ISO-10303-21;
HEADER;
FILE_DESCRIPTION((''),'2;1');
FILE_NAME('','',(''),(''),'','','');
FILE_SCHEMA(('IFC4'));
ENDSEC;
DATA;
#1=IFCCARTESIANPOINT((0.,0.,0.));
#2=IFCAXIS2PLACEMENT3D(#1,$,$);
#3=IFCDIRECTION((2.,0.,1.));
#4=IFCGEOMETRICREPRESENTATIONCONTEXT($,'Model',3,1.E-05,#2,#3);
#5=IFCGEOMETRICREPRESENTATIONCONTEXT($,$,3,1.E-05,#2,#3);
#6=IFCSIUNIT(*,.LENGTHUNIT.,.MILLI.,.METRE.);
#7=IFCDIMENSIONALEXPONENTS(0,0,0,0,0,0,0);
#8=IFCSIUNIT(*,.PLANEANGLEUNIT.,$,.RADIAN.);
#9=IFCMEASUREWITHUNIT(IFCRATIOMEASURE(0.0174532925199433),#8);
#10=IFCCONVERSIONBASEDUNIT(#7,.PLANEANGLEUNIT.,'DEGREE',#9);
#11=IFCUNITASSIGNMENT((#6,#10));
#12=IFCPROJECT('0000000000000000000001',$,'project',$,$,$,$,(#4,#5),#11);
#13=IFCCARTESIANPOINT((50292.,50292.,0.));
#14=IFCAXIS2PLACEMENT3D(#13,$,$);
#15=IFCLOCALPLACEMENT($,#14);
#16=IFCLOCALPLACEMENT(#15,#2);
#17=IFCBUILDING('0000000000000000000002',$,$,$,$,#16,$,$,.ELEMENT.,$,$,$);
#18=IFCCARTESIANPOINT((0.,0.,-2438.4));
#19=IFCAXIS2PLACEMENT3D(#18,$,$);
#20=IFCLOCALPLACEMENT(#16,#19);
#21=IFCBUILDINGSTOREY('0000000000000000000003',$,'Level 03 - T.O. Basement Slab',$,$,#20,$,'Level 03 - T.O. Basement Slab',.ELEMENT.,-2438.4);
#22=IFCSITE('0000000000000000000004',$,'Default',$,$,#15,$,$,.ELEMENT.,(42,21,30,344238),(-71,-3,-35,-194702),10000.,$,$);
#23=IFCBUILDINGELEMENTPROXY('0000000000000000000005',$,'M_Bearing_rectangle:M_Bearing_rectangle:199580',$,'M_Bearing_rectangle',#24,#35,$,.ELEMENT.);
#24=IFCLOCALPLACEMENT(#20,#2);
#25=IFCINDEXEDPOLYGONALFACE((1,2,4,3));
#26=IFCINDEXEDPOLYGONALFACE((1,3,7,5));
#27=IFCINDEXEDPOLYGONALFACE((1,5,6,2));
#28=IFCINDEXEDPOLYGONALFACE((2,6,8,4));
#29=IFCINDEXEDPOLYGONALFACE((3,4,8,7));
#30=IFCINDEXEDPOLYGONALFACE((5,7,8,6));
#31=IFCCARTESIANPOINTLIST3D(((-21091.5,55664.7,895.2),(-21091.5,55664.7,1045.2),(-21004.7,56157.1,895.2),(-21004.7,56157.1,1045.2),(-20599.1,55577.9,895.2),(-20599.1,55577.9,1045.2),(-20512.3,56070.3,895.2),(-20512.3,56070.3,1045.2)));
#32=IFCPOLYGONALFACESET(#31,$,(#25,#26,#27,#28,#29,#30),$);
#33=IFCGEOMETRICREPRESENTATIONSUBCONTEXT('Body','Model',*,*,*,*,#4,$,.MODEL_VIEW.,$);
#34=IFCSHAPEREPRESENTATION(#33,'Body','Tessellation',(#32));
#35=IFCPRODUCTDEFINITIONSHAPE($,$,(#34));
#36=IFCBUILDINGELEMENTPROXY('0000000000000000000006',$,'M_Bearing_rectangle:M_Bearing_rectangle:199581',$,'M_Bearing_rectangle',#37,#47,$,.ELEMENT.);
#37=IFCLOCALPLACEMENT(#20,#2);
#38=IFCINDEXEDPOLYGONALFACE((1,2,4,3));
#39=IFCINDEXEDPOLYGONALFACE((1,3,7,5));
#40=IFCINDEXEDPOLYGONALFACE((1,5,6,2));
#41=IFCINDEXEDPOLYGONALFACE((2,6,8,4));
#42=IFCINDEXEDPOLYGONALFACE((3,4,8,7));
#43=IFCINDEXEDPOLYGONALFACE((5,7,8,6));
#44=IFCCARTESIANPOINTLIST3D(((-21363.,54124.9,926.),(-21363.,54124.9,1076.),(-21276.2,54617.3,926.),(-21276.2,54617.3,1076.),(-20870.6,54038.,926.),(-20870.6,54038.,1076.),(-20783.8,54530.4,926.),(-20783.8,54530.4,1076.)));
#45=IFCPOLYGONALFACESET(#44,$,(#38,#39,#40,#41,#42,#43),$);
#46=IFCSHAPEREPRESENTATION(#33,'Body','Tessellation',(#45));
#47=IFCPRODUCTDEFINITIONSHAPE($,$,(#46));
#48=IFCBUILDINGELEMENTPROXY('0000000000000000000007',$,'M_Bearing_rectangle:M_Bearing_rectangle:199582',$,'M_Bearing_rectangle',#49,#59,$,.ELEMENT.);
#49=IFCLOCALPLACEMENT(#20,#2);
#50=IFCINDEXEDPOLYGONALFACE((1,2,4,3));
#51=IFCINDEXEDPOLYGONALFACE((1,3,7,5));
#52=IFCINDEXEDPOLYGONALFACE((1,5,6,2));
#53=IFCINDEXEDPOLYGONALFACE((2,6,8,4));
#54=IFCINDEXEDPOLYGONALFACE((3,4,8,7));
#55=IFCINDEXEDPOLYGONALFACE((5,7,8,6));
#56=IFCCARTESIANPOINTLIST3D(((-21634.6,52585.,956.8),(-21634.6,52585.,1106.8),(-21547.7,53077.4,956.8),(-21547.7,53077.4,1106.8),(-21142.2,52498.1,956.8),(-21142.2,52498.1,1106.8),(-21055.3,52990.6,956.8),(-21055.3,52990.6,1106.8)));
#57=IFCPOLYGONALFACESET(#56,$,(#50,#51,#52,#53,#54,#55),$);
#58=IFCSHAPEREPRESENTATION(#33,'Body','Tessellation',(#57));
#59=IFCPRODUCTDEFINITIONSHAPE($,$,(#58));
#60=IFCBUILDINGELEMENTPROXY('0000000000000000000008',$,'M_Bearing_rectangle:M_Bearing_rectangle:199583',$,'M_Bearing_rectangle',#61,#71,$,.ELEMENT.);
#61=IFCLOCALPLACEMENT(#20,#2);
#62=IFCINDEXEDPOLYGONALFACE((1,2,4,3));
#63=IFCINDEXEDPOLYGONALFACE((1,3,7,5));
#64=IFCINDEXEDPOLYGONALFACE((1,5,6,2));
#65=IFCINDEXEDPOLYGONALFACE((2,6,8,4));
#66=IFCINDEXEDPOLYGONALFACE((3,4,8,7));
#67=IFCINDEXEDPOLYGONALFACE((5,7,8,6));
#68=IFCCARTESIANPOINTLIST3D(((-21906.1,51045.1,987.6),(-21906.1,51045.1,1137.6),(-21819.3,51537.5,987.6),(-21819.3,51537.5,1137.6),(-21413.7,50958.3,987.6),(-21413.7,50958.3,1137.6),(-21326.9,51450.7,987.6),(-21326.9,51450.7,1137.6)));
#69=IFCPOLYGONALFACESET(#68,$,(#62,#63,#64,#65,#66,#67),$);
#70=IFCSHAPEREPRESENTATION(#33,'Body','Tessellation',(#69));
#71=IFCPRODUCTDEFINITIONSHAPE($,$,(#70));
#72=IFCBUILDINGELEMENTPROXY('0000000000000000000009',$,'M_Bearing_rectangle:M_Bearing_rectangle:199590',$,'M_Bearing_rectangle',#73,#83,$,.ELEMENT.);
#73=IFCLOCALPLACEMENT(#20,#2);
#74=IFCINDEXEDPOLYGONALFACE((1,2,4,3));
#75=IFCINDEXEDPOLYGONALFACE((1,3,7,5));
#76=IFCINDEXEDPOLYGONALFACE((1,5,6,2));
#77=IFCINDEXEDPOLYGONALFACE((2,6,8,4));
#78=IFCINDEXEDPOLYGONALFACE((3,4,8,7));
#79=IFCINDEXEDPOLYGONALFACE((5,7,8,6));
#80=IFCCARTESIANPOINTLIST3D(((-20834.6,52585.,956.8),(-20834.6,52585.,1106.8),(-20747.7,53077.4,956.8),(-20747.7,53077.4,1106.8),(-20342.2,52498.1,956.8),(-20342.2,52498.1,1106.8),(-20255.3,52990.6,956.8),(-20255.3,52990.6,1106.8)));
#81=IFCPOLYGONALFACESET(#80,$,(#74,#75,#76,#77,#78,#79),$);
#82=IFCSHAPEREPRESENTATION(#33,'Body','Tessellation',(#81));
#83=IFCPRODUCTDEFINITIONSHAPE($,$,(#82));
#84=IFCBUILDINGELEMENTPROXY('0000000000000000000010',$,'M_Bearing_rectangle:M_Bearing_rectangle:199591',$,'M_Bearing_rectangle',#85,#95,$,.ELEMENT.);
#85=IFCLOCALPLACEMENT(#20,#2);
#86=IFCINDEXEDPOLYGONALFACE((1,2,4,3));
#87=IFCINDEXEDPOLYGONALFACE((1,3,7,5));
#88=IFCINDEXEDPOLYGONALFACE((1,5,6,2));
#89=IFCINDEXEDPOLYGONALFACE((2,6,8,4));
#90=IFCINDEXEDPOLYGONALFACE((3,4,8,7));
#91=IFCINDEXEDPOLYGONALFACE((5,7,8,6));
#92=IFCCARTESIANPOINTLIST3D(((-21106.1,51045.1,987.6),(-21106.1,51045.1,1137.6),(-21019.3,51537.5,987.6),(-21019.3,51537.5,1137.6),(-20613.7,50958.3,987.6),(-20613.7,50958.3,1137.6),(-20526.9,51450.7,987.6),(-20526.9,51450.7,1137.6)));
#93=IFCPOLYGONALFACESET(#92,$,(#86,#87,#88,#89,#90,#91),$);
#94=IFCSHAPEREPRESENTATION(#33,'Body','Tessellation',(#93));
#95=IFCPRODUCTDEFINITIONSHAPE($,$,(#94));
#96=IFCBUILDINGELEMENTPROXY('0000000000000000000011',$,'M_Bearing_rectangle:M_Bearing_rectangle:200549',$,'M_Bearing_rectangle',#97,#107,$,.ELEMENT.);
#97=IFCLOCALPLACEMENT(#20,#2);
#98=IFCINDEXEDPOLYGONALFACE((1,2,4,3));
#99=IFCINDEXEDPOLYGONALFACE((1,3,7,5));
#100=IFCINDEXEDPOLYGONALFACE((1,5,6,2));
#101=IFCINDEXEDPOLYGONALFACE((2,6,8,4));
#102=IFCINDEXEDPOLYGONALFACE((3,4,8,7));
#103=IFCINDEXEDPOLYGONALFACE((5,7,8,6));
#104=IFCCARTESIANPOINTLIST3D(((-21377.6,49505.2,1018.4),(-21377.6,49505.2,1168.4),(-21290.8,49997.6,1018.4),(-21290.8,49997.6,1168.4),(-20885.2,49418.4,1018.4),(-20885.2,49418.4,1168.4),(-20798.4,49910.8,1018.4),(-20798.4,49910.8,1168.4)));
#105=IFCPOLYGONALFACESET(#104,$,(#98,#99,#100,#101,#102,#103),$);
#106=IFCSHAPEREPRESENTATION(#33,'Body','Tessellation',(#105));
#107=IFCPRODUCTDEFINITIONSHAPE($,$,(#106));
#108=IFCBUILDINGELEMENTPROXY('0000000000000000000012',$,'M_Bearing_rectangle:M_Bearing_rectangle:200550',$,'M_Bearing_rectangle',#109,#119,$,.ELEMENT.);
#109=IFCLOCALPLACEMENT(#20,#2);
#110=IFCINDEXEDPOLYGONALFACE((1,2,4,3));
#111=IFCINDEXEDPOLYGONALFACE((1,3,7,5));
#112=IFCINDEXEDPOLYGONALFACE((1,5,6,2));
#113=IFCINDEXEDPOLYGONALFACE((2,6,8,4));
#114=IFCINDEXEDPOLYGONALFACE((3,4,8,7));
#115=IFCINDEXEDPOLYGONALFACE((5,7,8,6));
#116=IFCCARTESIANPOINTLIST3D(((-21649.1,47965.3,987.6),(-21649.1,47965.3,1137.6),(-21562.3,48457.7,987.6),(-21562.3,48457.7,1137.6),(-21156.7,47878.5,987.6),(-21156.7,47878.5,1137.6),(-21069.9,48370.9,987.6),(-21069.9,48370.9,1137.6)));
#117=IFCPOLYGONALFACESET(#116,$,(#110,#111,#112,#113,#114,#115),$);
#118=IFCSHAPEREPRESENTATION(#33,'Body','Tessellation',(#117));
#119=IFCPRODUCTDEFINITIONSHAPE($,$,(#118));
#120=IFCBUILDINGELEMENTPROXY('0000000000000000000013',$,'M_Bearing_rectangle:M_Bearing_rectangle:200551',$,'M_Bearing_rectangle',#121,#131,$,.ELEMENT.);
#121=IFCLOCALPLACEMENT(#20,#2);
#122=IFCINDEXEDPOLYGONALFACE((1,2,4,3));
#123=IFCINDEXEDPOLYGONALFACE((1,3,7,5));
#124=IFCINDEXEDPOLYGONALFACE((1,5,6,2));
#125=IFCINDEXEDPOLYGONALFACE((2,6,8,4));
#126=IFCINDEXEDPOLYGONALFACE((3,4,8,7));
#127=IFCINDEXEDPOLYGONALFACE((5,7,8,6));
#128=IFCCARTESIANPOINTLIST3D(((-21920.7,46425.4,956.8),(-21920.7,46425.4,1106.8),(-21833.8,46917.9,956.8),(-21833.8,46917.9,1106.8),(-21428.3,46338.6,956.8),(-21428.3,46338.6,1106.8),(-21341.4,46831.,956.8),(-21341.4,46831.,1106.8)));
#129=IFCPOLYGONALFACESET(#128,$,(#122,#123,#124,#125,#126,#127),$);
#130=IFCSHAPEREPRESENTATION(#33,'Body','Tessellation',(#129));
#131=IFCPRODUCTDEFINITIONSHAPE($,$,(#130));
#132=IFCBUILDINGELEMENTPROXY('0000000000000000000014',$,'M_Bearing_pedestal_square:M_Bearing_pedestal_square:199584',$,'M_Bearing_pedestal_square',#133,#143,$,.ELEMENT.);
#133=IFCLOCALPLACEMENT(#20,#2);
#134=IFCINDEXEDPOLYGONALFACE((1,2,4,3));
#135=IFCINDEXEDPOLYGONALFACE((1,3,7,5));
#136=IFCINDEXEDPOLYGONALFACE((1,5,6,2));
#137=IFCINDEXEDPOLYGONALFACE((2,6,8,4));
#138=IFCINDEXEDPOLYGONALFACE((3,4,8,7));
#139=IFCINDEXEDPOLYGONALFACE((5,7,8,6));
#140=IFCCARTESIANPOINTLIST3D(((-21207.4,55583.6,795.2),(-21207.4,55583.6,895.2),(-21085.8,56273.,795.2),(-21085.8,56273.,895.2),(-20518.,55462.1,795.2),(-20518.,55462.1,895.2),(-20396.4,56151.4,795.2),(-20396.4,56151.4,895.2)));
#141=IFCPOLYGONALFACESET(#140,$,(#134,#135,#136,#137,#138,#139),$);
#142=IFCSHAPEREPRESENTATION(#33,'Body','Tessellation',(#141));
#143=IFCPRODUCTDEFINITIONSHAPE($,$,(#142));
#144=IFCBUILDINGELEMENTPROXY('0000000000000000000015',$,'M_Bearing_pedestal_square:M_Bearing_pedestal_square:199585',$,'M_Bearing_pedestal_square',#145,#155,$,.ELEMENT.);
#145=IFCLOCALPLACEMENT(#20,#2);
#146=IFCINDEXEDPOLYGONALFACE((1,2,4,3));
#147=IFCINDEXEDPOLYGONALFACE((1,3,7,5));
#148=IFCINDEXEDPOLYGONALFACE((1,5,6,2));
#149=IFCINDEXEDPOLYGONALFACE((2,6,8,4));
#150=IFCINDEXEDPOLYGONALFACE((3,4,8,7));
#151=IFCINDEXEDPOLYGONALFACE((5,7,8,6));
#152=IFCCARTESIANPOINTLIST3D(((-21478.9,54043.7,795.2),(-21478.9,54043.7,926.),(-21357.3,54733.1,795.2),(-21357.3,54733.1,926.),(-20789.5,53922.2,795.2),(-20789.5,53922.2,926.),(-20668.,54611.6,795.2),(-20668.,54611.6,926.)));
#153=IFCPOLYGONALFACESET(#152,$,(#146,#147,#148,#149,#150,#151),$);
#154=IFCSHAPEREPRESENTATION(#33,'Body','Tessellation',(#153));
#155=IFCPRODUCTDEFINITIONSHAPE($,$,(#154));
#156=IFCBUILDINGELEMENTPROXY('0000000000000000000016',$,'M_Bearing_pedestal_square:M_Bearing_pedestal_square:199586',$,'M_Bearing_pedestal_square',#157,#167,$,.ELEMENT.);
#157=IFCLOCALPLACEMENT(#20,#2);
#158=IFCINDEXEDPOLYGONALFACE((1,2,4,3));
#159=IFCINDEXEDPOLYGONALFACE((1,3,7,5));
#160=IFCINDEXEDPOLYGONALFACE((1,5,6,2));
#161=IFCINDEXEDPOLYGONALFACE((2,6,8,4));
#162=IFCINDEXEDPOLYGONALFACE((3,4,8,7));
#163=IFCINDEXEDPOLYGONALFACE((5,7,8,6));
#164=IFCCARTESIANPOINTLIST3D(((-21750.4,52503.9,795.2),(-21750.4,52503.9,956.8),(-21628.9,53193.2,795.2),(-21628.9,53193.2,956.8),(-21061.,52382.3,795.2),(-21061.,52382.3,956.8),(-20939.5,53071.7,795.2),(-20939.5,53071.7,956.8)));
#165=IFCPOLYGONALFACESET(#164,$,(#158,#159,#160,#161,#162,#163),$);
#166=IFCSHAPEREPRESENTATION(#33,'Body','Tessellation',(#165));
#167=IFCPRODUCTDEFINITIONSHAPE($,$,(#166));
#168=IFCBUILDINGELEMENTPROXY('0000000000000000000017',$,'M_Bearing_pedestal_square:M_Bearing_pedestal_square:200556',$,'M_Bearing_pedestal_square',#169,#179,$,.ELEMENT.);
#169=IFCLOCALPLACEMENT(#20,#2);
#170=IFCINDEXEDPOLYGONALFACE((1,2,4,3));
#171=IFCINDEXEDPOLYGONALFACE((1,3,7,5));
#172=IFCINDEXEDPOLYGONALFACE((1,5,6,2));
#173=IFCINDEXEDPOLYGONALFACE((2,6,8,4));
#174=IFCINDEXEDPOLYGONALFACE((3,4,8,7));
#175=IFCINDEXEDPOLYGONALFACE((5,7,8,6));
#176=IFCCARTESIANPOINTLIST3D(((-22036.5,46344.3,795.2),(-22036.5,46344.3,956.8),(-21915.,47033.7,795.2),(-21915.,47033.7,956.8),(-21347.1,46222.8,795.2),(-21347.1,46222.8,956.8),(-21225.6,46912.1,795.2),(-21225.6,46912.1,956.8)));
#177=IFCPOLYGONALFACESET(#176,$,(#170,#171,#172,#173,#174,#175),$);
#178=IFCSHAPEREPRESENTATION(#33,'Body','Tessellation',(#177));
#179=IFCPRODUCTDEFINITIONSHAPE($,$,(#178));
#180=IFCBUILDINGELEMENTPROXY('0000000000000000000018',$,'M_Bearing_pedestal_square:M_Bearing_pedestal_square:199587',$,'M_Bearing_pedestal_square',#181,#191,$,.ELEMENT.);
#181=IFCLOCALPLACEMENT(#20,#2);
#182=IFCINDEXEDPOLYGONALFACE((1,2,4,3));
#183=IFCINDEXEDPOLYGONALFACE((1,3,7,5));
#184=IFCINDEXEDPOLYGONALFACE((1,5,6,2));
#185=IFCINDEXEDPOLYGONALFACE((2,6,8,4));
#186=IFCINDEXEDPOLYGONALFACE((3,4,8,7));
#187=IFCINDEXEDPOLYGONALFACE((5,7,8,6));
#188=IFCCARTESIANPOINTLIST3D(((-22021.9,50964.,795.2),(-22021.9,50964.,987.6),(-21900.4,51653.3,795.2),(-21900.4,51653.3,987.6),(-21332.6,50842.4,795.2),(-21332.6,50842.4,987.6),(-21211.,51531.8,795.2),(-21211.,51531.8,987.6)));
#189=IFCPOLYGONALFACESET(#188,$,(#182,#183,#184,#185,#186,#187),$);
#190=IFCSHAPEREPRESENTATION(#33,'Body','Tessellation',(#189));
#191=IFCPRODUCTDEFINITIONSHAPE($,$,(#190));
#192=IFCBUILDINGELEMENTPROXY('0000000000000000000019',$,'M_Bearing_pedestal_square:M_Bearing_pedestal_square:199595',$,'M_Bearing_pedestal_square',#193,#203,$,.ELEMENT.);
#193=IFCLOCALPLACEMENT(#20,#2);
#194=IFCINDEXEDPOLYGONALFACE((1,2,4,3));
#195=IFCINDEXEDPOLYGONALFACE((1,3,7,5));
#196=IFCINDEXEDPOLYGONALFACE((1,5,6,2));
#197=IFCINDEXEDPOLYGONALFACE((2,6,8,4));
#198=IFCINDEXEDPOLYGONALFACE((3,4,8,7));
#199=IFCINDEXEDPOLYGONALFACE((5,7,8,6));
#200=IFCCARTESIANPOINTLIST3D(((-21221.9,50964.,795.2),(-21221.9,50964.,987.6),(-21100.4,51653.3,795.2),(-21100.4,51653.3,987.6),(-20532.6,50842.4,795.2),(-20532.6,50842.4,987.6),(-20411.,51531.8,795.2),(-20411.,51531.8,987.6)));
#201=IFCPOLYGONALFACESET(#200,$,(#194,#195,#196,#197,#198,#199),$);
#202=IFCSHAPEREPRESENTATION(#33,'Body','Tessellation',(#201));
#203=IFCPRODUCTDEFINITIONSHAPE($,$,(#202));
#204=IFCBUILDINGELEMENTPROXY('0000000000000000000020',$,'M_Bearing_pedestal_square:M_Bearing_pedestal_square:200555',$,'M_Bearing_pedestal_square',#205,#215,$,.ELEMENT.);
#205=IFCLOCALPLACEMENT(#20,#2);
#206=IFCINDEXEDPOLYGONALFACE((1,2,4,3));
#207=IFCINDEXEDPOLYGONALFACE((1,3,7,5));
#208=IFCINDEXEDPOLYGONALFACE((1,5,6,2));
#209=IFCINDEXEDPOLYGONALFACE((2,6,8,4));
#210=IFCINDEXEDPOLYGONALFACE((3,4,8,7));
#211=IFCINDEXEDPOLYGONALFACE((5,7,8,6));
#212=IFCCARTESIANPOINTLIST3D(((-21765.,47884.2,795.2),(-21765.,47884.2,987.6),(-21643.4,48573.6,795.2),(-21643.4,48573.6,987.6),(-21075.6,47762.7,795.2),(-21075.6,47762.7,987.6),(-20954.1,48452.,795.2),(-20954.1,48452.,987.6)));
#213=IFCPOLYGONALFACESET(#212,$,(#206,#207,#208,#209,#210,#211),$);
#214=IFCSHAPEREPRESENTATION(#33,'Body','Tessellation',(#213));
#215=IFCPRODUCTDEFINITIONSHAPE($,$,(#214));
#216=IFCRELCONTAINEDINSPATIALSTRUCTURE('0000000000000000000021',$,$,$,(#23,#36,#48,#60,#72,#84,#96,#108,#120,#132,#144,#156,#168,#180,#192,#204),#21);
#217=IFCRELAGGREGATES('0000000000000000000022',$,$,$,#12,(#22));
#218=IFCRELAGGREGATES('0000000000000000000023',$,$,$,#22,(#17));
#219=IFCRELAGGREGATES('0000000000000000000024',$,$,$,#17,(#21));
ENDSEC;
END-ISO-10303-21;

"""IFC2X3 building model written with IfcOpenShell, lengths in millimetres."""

from ifc_helpers import new_model, entity, si_unit, converted_unit, direction, frame, origin, origin_2d_with_axis, place, context, subcontext, project, spatial, rectangle, extrude, source, transform, mapped, element, save


model = new_model("IFC2X3")

# Units and contexts
model_context = context("Model", 3, precision=1e-05, world=origin(), true_north=direction((2.0, 0.0, 1.0)))
context_of_model = context(None, 3, precision=1e-05, world=origin(), true_north=direction((2.0, 0.0, 1.0)))
body_context = subcontext(model_context, "Body", "Model", "MODEL_VIEW")
ifc_project = project(units=[si_unit("LENGTHUNIT", "METRE", prefix="MILLI"), converted_unit("PLANEANGLEUNIT", "DEGREE", entity("IfcRatioMeasure", 0.0174532925199433), si_unit("PLANEANGLEUNIT", "RADIAN"), dimensions=[0, 0, 0, 0, 0, 0, 0])], contexts=[model_context, context_of_model])

# Site, building, storey
site_placement = place(None, frame((50292.0, 50292.0, 0.0)))
site = spatial("IfcSite", under=ifc_project, at=site_placement, Name="Default", CompositionType="ELEMENT", RefLatitude=(42, 21, 30, 344238), RefLongitude=(-71, -3, -35, -194702), RefElevation=10000.0)
building_placement = place(site_placement, origin())
building = spatial("IfcBuilding", under=site, at=building_placement, CompositionType="ELEMENT")
storey_placement = place(building_placement, frame((0.0, 0.0, -2438.4)))
storey = spatial("IfcBuildingStorey", under=building, at=storey_placement, Name="Level 03 - T.O. Basement Slab", LongName="Level 03 - T.O. Basement Slab", CompositionType="ELEMENT", Elevation=-2438.4)

# Building element proxies
shared_shape_1 = source(origin(), body_context, "Body", "SweptSolid", [
    extrude(rectangle(XDim=500.0, YDim=500.0, at=origin_2d_with_axis()), frame((0.0, 0.0, -150.0), z_axis=(0.0, 0.0, 1.0), x_axis=(-1.0, 0.0, 0.0)), (0.0, 0.0, 1.0), 150.0),
])
for number, where, z_axis, x_axis, name in (
    (1, (-20801.9, 55867.5, 1045.2), (0.0, 0.0, 1.0), (0.173648, 0.984808, 0.0), "M_Bearing_rectangle:M_Bearing_rectangle:199580"),
    (2, (-21073.4, 54327.6, 1076.0), (0.0, 0.0, 1.0), (0.173648, 0.984808, 0.0), "M_Bearing_rectangle:M_Bearing_rectangle:199581"),
    (3, (-21345.0, 52787.8, 1106.8), (0.0, 0.0, 1.0), (0.173648, 0.984808, 0.0), "M_Bearing_rectangle:M_Bearing_rectangle:199582"),
    (4, (-21616.5, 51247.9, 1137.6), (0.0, 0.0, 1.0), (0.173648, 0.984808, 0.0), "M_Bearing_rectangle:M_Bearing_rectangle:199583"),
    (5, (-20545.0, 52787.8, 1106.8), (0.0, 0.0, 1.0), (0.173648, 0.984808, 0.0), "M_Bearing_rectangle:M_Bearing_rectangle:199590"),
    (6, (-20816.5, 51247.9, 1137.6), (0.0, 0.0, 1.0), (0.173648, 0.984808, 0.0), "M_Bearing_rectangle:M_Bearing_rectangle:199591"),
    (7, (-21088.0, 49708.0, 1168.4), (0.0, 0.0, 1.0), (0.173648, 0.984808, 0.0), "M_Bearing_rectangle:M_Bearing_rectangle:200549"),
    (8, (-21359.5, 48168.1, 1137.6), (0.0, 0.0, 1.0), (0.173648, 0.984808, 0.0), "M_Bearing_rectangle:M_Bearing_rectangle:200550"),
    (9, (-21631.0, 46628.2, 1106.8), (0.0, 0.0, 1.0), (0.173648, 0.984808, 0.0), "M_Bearing_rectangle:M_Bearing_rectangle:200551"),
):
    element("IfcBuildingElementProxy", number, at=place(storey_placement, frame(where, z_axis=z_axis, x_axis=x_axis)), inside=storey, Name=name, ObjectType="M_Bearing_rectangle", CompositionType="ELEMENT", context=body_context, shape_type="MappedRepresentation", body=[
        mapped(shared_shape_1, transform((0.0, 0.0, 0.0), scale=1.0)),
    ])
shared_shape_2 = source(origin(), body_context, "Body", "SweptSolid", [
    extrude(rectangle(XDim=700.0, YDim=700.0, at=origin_2d_with_axis()), frame((0.0, 0.0, -100.0)), (0.0, 0.0, 1.0), 100.0),
])
proxy_1_placement = place(storey_placement, frame((-20801.9, 55867.5, 895.2), z_axis=(0.0, 0.0, 1.0), x_axis=(0.173648, 0.984808, 0.0)))
element("IfcBuildingElementProxy", 10, at=proxy_1_placement, inside=storey, Name="M_Bearing_pedestal_square:M_Bearing_pedestal_square:199584", ObjectType="M_Bearing_pedestal_square", CompositionType="ELEMENT", context=body_context, shape_type="MappedRepresentation", body=[
    mapped(shared_shape_2, transform((0.0, 0.0, 0.0), scale=1.0)),
])
shared_shape_3 = source(origin(), body_context, "Body", "SweptSolid", [
    extrude(rectangle(XDim=700.0, YDim=700.0, at=origin_2d_with_axis()), frame((0.0, 0.0, -130.8)), (0.0, 0.0, 1.0), 130.8),
])
proxy_2_placement = place(storey_placement, frame((-21073.4, 54327.6, 926.0), z_axis=(0.0, 0.0, 1.0), x_axis=(0.173648, 0.984808, 0.0)))
element("IfcBuildingElementProxy", 11, at=proxy_2_placement, inside=storey, Name="M_Bearing_pedestal_square:M_Bearing_pedestal_square:199585", ObjectType="M_Bearing_pedestal_square", CompositionType="ELEMENT", context=body_context, shape_type="MappedRepresentation", body=[
    mapped(shared_shape_3, transform((0.0, 0.0, 0.0), scale=1.0)),
])
shared_shape_4 = source(origin(), body_context, "Body", "SweptSolid", [
    extrude(rectangle(XDim=700.0, YDim=700.0, at=origin_2d_with_axis()), frame((0.0, 0.0, -161.6)), (0.0, 0.0, 1.0), 161.6),
])
for number, where, z_axis, x_axis, name in (
    (12, (-21345.0, 52787.8, 956.8), (0.0, 0.0, 1.0), (0.173648, 0.984808, 0.0), "M_Bearing_pedestal_square:M_Bearing_pedestal_square:199586"),
    (13, (-21631.0, 46628.2, 956.8), (0.0, 0.0, 1.0), (0.173648, 0.984808, 0.0), "M_Bearing_pedestal_square:M_Bearing_pedestal_square:200556"),
):
    element("IfcBuildingElementProxy", number, at=place(storey_placement, frame(where, z_axis=z_axis, x_axis=x_axis)), inside=storey, Name=name, ObjectType="M_Bearing_pedestal_square", CompositionType="ELEMENT", context=body_context, shape_type="MappedRepresentation", body=[
        mapped(shared_shape_4, transform((0.0, 0.0, 0.0), scale=1.0)),
    ])
shared_shape_5 = source(origin(), body_context, "Body", "SweptSolid", [
    extrude(rectangle(XDim=700.0, YDim=700.0, at=origin_2d_with_axis()), frame((0.0, 0.0, -192.4)), (0.0, 0.0, 1.0), 192.4),
])
for number, where, z_axis, x_axis, name in (
    (14, (-21616.5, 51247.9, 987.6), (0.0, 0.0, 1.0), (0.173648, 0.984808, 0.0), "M_Bearing_pedestal_square:M_Bearing_pedestal_square:199587"),
    (15, (-20816.5, 51247.9, 987.6), (0.0, 0.0, 1.0), (0.173648, 0.984808, 0.0), "M_Bearing_pedestal_square:M_Bearing_pedestal_square:199595"),
    (16, (-21359.5, 48168.1, 987.6), (0.0, 0.0, 1.0), (0.173648, 0.984808, 0.0), "M_Bearing_pedestal_square:M_Bearing_pedestal_square:200555"),
):
    element("IfcBuildingElementProxy", number, at=place(storey_placement, frame(where, z_axis=z_axis, x_axis=x_axis)), inside=storey, Name=name, ObjectType="M_Bearing_pedestal_square", CompositionType="ELEMENT", context=body_context, shape_type="MappedRepresentation", body=[
        mapped(shared_shape_5, transform((0.0, 0.0, 0.0), scale=1.0)),
    ])

save(model, "model.ifc")
